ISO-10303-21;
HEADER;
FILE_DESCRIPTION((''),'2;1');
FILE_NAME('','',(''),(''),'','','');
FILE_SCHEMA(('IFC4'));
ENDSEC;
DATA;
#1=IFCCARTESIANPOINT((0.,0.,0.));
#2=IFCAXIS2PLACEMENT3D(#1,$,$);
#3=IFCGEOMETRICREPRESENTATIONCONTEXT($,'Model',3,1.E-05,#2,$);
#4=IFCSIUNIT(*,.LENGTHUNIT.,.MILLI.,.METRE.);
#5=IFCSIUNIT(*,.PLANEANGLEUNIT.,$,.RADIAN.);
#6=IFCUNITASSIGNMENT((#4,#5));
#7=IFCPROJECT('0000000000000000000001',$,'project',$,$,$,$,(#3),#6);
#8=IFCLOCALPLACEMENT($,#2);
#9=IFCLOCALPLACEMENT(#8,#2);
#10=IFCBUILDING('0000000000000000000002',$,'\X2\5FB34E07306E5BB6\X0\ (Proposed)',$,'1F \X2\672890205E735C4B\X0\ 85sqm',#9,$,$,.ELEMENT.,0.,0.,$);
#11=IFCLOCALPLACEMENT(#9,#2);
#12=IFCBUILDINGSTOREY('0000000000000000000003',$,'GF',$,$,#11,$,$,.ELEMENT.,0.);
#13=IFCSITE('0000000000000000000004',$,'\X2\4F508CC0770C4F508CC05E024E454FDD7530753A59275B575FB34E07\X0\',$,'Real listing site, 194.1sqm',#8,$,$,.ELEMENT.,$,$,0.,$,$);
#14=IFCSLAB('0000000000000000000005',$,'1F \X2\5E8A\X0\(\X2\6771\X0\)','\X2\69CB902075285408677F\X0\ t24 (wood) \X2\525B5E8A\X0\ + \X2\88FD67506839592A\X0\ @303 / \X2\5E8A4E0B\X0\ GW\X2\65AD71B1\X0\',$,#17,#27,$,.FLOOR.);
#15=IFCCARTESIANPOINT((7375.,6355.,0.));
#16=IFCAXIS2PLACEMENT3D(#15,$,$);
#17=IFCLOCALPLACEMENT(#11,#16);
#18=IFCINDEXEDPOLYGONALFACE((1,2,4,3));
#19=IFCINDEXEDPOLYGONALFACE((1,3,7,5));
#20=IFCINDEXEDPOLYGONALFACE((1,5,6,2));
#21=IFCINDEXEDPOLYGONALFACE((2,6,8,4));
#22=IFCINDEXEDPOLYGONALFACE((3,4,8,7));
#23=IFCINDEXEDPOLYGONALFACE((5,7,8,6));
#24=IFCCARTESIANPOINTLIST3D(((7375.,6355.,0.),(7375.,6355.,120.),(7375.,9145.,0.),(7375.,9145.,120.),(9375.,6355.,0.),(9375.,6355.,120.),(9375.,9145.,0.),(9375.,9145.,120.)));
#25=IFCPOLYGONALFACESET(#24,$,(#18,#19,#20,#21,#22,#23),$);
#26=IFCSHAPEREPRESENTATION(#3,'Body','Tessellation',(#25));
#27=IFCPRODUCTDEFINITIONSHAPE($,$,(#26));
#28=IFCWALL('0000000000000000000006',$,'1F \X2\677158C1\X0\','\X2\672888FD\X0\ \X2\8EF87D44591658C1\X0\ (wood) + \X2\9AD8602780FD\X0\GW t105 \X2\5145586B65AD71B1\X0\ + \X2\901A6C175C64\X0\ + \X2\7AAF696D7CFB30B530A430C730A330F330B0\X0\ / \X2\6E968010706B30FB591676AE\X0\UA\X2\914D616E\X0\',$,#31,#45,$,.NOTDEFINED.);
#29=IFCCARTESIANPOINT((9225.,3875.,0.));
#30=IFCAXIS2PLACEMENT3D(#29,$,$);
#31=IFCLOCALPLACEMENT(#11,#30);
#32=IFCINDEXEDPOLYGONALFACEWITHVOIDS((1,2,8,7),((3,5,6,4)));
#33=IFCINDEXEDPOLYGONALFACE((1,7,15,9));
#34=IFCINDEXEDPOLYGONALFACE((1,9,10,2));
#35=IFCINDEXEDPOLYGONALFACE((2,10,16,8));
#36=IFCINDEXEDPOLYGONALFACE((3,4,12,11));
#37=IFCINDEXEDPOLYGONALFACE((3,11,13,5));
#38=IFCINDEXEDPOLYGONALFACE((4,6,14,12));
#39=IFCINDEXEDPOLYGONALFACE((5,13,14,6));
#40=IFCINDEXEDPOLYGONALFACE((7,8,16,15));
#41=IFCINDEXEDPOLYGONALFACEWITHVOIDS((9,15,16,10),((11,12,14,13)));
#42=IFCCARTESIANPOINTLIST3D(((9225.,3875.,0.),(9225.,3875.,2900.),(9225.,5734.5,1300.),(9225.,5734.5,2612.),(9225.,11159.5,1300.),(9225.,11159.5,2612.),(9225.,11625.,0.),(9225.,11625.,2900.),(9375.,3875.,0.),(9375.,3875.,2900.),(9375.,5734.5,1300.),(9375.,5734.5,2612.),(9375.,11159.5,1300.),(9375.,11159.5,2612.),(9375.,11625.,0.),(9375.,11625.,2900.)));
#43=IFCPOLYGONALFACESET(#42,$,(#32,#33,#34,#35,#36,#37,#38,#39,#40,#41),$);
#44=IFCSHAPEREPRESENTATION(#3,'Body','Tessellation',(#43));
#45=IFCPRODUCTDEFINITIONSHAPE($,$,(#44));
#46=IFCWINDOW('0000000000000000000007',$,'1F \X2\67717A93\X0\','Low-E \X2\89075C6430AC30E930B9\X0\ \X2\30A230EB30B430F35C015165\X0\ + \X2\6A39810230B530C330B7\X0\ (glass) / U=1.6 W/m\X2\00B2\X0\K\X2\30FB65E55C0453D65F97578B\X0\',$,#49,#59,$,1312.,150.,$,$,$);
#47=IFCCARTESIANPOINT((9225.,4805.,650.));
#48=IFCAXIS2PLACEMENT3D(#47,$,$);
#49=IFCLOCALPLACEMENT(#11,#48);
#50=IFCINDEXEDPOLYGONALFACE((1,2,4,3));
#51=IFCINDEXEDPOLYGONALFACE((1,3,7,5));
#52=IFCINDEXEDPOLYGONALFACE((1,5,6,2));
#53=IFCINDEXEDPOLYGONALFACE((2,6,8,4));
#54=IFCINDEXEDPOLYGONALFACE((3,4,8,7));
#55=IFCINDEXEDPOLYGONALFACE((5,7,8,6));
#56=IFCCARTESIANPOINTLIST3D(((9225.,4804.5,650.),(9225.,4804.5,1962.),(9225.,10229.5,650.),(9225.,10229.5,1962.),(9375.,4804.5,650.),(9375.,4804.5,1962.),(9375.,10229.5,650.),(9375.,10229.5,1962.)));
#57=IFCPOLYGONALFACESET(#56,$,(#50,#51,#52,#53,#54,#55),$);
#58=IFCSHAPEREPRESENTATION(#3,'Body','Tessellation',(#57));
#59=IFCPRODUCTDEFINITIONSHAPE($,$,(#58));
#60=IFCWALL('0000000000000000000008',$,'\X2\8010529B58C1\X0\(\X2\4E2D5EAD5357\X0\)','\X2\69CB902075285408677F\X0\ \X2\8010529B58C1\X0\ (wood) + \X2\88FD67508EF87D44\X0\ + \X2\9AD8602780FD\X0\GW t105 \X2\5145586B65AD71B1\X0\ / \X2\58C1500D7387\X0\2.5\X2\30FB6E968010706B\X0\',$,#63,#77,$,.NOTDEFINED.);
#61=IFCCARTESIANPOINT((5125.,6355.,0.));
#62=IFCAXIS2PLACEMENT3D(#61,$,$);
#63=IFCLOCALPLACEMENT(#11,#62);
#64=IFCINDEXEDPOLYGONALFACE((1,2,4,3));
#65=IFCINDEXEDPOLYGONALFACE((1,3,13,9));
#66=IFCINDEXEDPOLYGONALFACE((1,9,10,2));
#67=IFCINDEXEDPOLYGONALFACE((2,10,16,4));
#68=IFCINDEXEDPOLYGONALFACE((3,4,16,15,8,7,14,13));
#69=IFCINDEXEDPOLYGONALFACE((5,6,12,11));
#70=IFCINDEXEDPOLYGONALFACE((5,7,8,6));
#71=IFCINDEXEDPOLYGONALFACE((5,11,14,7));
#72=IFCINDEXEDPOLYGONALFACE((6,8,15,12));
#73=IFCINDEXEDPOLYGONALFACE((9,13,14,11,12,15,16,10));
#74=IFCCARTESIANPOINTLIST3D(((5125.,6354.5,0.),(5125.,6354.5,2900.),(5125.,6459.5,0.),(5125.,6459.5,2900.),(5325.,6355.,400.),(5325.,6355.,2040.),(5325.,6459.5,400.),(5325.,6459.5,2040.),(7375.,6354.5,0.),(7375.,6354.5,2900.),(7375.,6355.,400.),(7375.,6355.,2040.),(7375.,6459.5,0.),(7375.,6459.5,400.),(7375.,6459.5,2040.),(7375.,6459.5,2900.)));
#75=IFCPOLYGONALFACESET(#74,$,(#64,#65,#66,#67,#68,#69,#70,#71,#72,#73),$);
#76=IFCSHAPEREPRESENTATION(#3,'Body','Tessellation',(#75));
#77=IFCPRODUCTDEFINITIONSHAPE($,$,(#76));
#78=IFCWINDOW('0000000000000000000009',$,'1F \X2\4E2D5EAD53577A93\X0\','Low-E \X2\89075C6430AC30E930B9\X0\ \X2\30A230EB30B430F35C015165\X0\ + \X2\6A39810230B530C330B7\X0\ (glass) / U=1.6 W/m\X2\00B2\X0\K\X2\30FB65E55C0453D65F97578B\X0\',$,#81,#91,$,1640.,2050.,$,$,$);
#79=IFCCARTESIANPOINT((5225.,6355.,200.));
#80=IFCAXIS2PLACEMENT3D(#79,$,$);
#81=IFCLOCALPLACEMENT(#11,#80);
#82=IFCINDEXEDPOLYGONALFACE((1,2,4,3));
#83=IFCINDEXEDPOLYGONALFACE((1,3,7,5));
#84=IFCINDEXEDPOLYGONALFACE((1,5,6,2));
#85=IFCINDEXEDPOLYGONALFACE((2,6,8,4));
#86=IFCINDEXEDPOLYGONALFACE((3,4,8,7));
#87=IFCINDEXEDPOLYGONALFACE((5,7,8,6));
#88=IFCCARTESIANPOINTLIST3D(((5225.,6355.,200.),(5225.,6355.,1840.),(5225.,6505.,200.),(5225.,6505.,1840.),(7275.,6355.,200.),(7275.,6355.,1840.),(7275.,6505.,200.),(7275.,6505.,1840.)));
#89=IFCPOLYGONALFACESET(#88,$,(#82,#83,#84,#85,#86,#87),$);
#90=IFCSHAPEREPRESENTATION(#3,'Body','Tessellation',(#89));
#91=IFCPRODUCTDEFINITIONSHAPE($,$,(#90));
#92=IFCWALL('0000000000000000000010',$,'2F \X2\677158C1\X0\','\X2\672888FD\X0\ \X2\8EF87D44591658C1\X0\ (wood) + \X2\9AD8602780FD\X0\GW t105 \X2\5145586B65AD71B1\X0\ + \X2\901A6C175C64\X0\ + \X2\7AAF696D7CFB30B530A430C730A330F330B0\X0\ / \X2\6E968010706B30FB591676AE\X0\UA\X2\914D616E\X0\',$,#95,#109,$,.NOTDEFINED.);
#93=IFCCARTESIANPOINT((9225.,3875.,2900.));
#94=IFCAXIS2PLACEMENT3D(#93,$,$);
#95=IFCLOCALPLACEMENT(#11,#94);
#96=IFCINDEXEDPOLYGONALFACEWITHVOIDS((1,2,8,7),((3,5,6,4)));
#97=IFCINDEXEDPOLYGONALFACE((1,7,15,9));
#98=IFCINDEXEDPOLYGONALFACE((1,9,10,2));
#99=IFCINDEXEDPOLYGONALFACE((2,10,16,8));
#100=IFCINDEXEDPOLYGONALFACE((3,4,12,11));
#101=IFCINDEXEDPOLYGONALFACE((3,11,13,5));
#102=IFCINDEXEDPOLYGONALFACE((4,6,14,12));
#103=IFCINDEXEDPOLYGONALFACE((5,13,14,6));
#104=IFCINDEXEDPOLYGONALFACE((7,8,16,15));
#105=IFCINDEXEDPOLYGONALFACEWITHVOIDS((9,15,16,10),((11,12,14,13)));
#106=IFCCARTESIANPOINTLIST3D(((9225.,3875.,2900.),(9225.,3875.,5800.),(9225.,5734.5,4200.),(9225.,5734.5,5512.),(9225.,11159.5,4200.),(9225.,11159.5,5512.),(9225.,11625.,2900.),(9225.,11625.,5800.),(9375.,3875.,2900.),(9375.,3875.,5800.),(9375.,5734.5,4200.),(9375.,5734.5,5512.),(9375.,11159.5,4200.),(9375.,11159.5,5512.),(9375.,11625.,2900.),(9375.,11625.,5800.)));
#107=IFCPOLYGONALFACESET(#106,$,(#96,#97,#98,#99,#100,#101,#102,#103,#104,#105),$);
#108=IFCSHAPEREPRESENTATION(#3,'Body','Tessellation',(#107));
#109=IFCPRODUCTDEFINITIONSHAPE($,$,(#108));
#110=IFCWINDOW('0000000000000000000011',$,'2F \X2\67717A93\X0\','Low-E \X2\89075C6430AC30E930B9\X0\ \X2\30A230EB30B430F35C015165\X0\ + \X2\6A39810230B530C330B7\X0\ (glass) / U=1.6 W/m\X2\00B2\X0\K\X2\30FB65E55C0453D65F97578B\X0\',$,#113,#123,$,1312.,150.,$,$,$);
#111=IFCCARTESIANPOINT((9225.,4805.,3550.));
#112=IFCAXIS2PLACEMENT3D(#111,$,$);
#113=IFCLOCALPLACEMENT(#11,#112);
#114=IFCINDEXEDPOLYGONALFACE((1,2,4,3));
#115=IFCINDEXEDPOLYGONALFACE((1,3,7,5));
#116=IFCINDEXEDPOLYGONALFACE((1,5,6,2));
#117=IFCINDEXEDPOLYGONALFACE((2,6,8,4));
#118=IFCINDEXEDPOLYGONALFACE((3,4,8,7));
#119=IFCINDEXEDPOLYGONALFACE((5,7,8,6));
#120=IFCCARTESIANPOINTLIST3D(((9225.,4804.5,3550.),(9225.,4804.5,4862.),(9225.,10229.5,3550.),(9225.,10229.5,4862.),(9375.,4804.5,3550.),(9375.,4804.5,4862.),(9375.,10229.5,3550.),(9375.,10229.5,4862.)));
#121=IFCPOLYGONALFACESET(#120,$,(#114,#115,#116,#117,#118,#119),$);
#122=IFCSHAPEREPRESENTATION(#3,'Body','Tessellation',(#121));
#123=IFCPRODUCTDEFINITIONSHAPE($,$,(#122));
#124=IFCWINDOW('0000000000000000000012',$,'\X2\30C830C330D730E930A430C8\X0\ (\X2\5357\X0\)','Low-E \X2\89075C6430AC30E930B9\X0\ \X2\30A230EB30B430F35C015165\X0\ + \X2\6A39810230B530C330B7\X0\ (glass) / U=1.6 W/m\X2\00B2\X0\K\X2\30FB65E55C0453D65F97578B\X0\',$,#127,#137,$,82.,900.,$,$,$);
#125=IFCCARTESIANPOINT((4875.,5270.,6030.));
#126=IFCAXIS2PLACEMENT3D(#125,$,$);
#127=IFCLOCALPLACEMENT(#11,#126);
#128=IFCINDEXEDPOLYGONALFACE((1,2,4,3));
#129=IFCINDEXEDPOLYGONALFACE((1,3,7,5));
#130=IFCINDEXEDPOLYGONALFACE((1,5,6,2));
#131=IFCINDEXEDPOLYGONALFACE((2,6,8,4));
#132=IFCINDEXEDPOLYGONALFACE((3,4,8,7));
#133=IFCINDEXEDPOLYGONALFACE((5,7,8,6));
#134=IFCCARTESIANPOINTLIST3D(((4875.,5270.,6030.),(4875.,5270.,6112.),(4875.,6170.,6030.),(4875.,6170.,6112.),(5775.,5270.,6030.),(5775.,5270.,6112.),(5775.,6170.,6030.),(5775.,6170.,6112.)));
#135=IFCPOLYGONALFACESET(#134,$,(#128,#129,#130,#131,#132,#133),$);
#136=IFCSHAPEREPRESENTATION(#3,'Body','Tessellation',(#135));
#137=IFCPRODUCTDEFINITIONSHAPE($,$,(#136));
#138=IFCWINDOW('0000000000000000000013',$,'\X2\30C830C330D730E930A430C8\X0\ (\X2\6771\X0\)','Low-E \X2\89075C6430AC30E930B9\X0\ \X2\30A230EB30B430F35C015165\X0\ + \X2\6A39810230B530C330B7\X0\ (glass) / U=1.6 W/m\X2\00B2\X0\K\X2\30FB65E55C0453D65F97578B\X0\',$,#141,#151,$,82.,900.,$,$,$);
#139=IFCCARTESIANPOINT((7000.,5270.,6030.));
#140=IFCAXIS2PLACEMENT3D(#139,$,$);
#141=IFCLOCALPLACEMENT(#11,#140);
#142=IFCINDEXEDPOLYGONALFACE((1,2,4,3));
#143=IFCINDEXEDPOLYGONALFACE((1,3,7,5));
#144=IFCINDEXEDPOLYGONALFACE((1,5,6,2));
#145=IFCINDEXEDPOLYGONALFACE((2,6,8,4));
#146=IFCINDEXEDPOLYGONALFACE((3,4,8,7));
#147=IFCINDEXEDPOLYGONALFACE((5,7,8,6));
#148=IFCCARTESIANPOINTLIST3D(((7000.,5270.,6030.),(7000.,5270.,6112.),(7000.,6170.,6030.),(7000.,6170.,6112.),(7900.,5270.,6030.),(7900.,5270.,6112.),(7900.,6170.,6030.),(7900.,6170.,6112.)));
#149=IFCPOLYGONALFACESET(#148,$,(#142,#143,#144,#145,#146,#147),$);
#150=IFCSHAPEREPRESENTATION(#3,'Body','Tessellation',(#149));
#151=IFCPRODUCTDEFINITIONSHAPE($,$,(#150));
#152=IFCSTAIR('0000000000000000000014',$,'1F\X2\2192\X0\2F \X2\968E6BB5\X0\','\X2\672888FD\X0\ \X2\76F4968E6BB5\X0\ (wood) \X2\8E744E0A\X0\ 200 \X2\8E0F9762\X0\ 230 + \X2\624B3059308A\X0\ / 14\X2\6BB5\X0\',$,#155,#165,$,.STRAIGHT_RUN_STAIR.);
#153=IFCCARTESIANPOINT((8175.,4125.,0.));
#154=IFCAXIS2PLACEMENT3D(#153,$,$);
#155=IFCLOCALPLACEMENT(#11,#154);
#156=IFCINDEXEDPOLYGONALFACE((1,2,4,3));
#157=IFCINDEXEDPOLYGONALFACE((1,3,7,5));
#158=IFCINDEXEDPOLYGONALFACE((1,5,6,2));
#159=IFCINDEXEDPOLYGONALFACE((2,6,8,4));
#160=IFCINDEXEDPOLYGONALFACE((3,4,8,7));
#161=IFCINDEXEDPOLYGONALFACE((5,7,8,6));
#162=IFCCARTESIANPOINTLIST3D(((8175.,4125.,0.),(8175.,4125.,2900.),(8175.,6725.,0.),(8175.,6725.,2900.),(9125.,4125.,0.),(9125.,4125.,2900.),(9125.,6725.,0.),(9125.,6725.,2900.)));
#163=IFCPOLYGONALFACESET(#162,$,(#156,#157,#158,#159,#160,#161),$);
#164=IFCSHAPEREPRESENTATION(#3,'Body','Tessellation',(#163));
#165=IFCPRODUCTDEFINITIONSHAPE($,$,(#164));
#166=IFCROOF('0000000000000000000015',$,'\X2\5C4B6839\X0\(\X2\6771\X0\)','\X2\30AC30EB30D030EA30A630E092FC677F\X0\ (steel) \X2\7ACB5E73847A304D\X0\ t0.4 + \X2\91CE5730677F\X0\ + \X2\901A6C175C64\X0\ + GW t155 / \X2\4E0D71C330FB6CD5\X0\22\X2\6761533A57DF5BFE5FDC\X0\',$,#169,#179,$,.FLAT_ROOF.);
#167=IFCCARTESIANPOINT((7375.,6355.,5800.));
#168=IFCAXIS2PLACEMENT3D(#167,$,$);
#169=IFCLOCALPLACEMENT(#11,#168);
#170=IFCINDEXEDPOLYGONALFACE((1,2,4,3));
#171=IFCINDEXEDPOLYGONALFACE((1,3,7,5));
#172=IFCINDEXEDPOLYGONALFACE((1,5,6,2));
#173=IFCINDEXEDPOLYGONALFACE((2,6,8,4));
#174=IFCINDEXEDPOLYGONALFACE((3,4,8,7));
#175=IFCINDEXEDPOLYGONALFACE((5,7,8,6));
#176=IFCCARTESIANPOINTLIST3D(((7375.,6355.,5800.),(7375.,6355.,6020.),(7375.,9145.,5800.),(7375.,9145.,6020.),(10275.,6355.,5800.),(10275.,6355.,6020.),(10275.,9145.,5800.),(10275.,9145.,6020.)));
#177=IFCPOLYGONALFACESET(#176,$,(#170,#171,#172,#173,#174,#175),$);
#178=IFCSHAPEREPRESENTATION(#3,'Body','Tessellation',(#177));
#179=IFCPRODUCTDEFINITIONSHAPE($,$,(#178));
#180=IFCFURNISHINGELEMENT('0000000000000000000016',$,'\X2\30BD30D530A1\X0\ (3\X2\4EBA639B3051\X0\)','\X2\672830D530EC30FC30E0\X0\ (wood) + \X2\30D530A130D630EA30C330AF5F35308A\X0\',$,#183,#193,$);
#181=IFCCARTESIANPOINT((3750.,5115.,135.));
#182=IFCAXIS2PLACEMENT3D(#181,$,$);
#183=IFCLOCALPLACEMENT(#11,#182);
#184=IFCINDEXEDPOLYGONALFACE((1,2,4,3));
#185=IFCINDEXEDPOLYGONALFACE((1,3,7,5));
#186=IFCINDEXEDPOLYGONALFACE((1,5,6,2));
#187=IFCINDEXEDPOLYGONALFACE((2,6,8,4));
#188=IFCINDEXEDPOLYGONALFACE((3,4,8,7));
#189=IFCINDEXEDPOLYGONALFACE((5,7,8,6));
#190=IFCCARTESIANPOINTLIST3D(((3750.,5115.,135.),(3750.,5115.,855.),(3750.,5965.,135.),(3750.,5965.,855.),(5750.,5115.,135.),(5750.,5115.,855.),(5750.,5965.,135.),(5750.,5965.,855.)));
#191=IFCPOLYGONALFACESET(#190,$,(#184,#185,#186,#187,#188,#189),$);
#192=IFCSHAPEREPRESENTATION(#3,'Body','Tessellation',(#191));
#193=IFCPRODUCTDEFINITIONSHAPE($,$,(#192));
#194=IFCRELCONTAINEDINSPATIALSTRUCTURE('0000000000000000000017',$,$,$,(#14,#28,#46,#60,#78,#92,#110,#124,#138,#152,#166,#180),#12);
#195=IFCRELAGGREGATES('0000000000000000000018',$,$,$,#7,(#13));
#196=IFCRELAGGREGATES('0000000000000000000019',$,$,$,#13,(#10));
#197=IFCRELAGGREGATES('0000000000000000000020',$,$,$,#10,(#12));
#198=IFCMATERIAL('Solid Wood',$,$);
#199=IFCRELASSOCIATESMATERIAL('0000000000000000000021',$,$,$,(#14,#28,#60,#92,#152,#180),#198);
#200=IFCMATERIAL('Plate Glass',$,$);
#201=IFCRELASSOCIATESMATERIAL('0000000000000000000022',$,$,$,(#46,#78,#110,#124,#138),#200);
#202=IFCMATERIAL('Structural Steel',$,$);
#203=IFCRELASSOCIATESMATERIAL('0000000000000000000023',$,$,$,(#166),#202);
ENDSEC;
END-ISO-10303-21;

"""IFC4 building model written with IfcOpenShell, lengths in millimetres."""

from ifc_helpers import new_model, si_unit, frame, frame_2d, origin, place, context, project, spatial, rectangle, extrude, material, element, fill, save


model = new_model("IFC4")

# Units and contexts
model_context = context("Model", 3, precision=1e-05, world=origin())
ifc_project = project(units=[si_unit("LENGTHUNIT", "METRE", prefix="MILLI"), si_unit("PLANEANGLEUNIT", "RADIAN")], contexts=[model_context])

# Site, building, storey
site_placement = place(None, origin())
site = spatial("IfcSite", under=ifc_project, at=site_placement, Name="佐賀県佐賀市久保田町大字徳万", ObjectType="Real listing site, 194.1sqm", CompositionType="ELEMENT", RefElevation=0.0)
building_placement = place(site_placement, origin())
building = spatial("IfcBuilding", under=site, at=building_placement, Name="徳万の家 (Proposed)", ObjectType="1F 木造平屋 85sqm", CompositionType="ELEMENT", ElevationOfRefHeight=0.0, ElevationOfTerrain=0.0)
storey_placement = place(building_placement, origin())
storey = spatial("IfcBuildingStorey", under=building, at=storey_placement, Name="GF", CompositionType="ELEMENT", Elevation=0.0)

# Slab
ifc_material_1 = material(Name="Solid Wood")
slab_placement = place(storey_placement, frame((7375.0, 6355.0, 0.0)))
element("IfcSlab", 1, at=slab_placement, inside=storey, material=ifc_material_1, Name="1F 床(東)", Description="構造用合板 t24 (wood) 剛床 + 製材根太 @303 / 床下 GW断熱", PredefinedType="FLOOR", context=model_context, shape_type="SweptSolid", body=[
    extrude(rectangle(XDim=2000.0, YDim=2790.0, at=frame_2d((1000.0, 1395.0))), frame((7375.0, 6355.0, 0.0)), (0.0, 0.0, 1.0), 120.0),
])

# Walls, openings, windows
wall_1_placement = place(storey_placement, frame((9225.0, 3875.0, 0.0)))
wall_1 = element("IfcWall", 2, at=wall_1_placement, inside=storey, material=ifc_material_1, Name="1F 東壁", Description="木製 軸組外壁 (wood) + 高性能GW t105 充填断熱 + 通気層 + 窯業系サイディング / 準耐火・外皮UA配慮", PredefinedType="NOTDEFINED", context=model_context, shape_type="SweptSolid", body=[
    extrude(rectangle(XDim=150.0, YDim=7750.0, at=frame_2d((75.0, 3875.0))), frame((9225.0, 3875.0, 0.0)), (0.0, 0.0, 1.0), 2900.0),
])
opening_1_placement = place(storey_placement, frame((9225.0, 4805.0, 650.0)))
opening_1 = element("IfcOpeningElement", 3, at=opening_1_placement, cuts=wall_1, PredefinedType="NOTDEFINED", context=model_context, shape_type="SweptSolid", body=[
    extrude(rectangle(XDim=150.0, YDim=5425.0, at=frame_2d((75.0, 2712.0))), frame((9225.0, 4805.0, 650.0)), (0.0, 0.0, 1.0), 1312.0),
])
ifc_material_2 = material(Name="Plate Glass")
window_1_placement = place(storey_placement, frame((9225.0, 4805.0, 650.0)))
window_1 = element("IfcWindow", 4, at=window_1_placement, inside=storey, material=ifc_material_2, Name="1F 東窓", Description="Low-E 複層ガラス アルゴン封入 + 樹脂サッシ (glass) / U=1.6 W/m²K・日射取得型", OverallHeight=1312.0, OverallWidth=150.0, context=model_context, shape_type="SweptSolid", body=[
    extrude(rectangle(XDim=150.0, YDim=5425.0, at=frame_2d((75.0, 2712.0))), frame((9225.0, 4805.0, 650.0)), (0.0, 0.0, 1.0), 1312.0),
])
fill(opening_1, window_1)
wall_2_placement = place(storey_placement, frame((5125.0, 6355.0, 0.0)))
wall_2 = element("IfcWall", 5, at=wall_2_placement, inside=storey, material=ifc_material_1, Name="耐力壁(中庭南)", Description="構造用合板 耐力壁 (wood) + 製材軸組 + 高性能GW t105 充填断熱 / 壁倍率2.5・準耐火", PredefinedType="NOTDEFINED", context=model_context, shape_type="SweptSolid", body=[
    extrude(rectangle(XDim=2250.0, YDim=105.0, at=frame_2d((1125.0, 52.0))), frame((5125.0, 6355.0, 0.0)), (0.0, 0.0, 1.0), 2900.0),
])
opening_2_placement = place(storey_placement, frame((5225.0, 6355.0, 200.0)))
opening_2 = element("IfcOpeningElement", 6, at=opening_2_placement, cuts=wall_2, PredefinedType="NOTDEFINED", context=model_context, shape_type="SweptSolid", body=[
    extrude(rectangle(XDim=2050.0, YDim=150.0, at=frame_2d((1025.0, 75.0))), frame((5225.0, 6355.0, 200.0)), (0.0, 0.0, 1.0), 1640.0),
])
window_2_placement = place(storey_placement, frame((5225.0, 6355.0, 200.0)))
window_2 = element("IfcWindow", 7, at=window_2_placement, inside=storey, material=ifc_material_2, Name="1F 中庭南窓", Description="Low-E 複層ガラス アルゴン封入 + 樹脂サッシ (glass) / U=1.6 W/m²K・日射取得型", OverallHeight=1640.0, OverallWidth=2050.0, context=model_context, shape_type="SweptSolid", body=[
    extrude(rectangle(XDim=2050.0, YDim=150.0, at=frame_2d((1025.0, 75.0))), frame((5225.0, 6355.0, 200.0)), (0.0, 0.0, 1.0), 1640.0),
])
fill(opening_2, window_2)

# Wall, opening, window
wall_3_placement = place(storey_placement, frame((9225.0, 3875.0, 2900.0)))
wall_3 = element("IfcWall", 8, at=wall_3_placement, inside=storey, material=ifc_material_1, Name="2F 東壁", Description="木製 軸組外壁 (wood) + 高性能GW t105 充填断熱 + 通気層 + 窯業系サイディング / 準耐火・外皮UA配慮", PredefinedType="NOTDEFINED", context=model_context, shape_type="SweptSolid", body=[
    extrude(rectangle(XDim=150.0, YDim=7750.0, at=frame_2d((75.0, 3875.0))), frame((9225.0, 3875.0, 2900.0)), (0.0, 0.0, 1.0), 2900.0),
])
opening_3_placement = place(storey_placement, frame((9225.0, 4805.0, 3550.0)))
opening_3 = element("IfcOpeningElement", 9, at=opening_3_placement, cuts=wall_3, PredefinedType="NOTDEFINED", context=model_context, shape_type="SweptSolid", body=[
    extrude(rectangle(XDim=150.0, YDim=5425.0, at=frame_2d((75.0, 2712.0))), frame((9225.0, 4805.0, 3550.0)), (0.0, 0.0, 1.0), 1312.0),
])
window_3_placement = place(storey_placement, frame((9225.0, 4805.0, 3550.0)))
window_3 = element("IfcWindow", 10, at=window_3_placement, inside=storey, material=ifc_material_2, Name="2F 東窓", Description="Low-E 複層ガラス アルゴン封入 + 樹脂サッシ (glass) / U=1.6 W/m²K・日射取得型", OverallHeight=1312.0, OverallWidth=150.0, context=model_context, shape_type="SweptSolid", body=[
    extrude(rectangle(XDim=150.0, YDim=5425.0, at=frame_2d((75.0, 2712.0))), frame((9225.0, 4805.0, 3550.0)), (0.0, 0.0, 1.0), 1312.0),
])
fill(opening_3, window_3)

# Windows
window_4_placement = place(storey_placement, frame((4875.0, 5270.0, 6030.0)))
element("IfcWindow", 11, at=window_4_placement, inside=storey, material=ifc_material_2, Name="トップライト (南)", Description="Low-E 複層ガラス アルゴン封入 + 樹脂サッシ (glass) / U=1.6 W/m²K・日射取得型", OverallHeight=82.0, OverallWidth=900.0, context=model_context, shape_type="SweptSolid", body=[
    extrude(rectangle(XDim=900.0, YDim=900.0, at=frame_2d((450.0, 450.0))), frame((4875.0, 5270.0, 6030.0)), (0.0, 0.0, 1.0), 82.0),
])
window_5_placement = place(storey_placement, frame((7000.0, 5270.0, 6030.0)))
element("IfcWindow", 12, at=window_5_placement, inside=storey, material=ifc_material_2, Name="トップライト (東)", Description="Low-E 複層ガラス アルゴン封入 + 樹脂サッシ (glass) / U=1.6 W/m²K・日射取得型", OverallHeight=82.0, OverallWidth=900.0, context=model_context, shape_type="SweptSolid", body=[
    extrude(rectangle(XDim=900.0, YDim=900.0, at=frame_2d((450.0, 450.0))), frame((7000.0, 5270.0, 6030.0)), (0.0, 0.0, 1.0), 82.0),
])

# Stair
stair_placement = place(storey_placement, frame((8175.0, 4125.0, 0.0)))
element("IfcStair", 13, at=stair_placement, inside=storey, material=ifc_material_1, Name="1F→2F 階段", Description="木製 直階段 (wood) 蹴上 200 踏面 230 + 手すり / 14段", PredefinedType="STRAIGHT_RUN_STAIR", context=model_context, shape_type="SweptSolid", body=[
    extrude(rectangle(XDim=950.0, YDim=2600.0, at=frame_2d((475.0, 1300.0))), frame((8175.0, 4125.0, 0.0)), (0.0, 0.0, 1.0), 2900.0),
])

# Roof
ifc_material_3 = material(Name="Structural Steel")
roof_placement = place(storey_placement, frame((7375.0, 6355.0, 5800.0)))
element("IfcRoof", 14, at=roof_placement, inside=storey, material=ifc_material_3, Name="屋根(東)", Description="ガルバリウム鋼板 (steel) 立平葺き t0.4 + 野地板 + 通気層 + GW t155 / 不燃・法22条区域対応", PredefinedType="FLAT_ROOF", context=model_context, shape_type="SweptSolid", body=[
    extrude(rectangle(XDim=2900.0, YDim=2790.0, at=frame_2d((1450.0, 1395.0))), frame((7375.0, 6355.0, 5800.0)), (0.0, 0.0, 1.0), 220.0),
])

# Furnishing element
furnishing_1_placement = place(storey_placement, frame((3750.0, 5115.0, 135.0)))
element("IfcFurnishingElement", 15, at=furnishing_1_placement, inside=storey, material=ifc_material_1, Name="ソファ (3人掛け)", Description="木フレーム (wood) + ファブリック張り", context=model_context, shape_type="SweptSolid", body=[
    extrude(rectangle(XDim=2000.0, YDim=850.0, at=frame_2d((1000.0, 425.0))), frame((3750.0, 5115.0, 135.0)), (0.0, 0.0, 1.0), 720.0),
])

save(model, "model.ifc")
